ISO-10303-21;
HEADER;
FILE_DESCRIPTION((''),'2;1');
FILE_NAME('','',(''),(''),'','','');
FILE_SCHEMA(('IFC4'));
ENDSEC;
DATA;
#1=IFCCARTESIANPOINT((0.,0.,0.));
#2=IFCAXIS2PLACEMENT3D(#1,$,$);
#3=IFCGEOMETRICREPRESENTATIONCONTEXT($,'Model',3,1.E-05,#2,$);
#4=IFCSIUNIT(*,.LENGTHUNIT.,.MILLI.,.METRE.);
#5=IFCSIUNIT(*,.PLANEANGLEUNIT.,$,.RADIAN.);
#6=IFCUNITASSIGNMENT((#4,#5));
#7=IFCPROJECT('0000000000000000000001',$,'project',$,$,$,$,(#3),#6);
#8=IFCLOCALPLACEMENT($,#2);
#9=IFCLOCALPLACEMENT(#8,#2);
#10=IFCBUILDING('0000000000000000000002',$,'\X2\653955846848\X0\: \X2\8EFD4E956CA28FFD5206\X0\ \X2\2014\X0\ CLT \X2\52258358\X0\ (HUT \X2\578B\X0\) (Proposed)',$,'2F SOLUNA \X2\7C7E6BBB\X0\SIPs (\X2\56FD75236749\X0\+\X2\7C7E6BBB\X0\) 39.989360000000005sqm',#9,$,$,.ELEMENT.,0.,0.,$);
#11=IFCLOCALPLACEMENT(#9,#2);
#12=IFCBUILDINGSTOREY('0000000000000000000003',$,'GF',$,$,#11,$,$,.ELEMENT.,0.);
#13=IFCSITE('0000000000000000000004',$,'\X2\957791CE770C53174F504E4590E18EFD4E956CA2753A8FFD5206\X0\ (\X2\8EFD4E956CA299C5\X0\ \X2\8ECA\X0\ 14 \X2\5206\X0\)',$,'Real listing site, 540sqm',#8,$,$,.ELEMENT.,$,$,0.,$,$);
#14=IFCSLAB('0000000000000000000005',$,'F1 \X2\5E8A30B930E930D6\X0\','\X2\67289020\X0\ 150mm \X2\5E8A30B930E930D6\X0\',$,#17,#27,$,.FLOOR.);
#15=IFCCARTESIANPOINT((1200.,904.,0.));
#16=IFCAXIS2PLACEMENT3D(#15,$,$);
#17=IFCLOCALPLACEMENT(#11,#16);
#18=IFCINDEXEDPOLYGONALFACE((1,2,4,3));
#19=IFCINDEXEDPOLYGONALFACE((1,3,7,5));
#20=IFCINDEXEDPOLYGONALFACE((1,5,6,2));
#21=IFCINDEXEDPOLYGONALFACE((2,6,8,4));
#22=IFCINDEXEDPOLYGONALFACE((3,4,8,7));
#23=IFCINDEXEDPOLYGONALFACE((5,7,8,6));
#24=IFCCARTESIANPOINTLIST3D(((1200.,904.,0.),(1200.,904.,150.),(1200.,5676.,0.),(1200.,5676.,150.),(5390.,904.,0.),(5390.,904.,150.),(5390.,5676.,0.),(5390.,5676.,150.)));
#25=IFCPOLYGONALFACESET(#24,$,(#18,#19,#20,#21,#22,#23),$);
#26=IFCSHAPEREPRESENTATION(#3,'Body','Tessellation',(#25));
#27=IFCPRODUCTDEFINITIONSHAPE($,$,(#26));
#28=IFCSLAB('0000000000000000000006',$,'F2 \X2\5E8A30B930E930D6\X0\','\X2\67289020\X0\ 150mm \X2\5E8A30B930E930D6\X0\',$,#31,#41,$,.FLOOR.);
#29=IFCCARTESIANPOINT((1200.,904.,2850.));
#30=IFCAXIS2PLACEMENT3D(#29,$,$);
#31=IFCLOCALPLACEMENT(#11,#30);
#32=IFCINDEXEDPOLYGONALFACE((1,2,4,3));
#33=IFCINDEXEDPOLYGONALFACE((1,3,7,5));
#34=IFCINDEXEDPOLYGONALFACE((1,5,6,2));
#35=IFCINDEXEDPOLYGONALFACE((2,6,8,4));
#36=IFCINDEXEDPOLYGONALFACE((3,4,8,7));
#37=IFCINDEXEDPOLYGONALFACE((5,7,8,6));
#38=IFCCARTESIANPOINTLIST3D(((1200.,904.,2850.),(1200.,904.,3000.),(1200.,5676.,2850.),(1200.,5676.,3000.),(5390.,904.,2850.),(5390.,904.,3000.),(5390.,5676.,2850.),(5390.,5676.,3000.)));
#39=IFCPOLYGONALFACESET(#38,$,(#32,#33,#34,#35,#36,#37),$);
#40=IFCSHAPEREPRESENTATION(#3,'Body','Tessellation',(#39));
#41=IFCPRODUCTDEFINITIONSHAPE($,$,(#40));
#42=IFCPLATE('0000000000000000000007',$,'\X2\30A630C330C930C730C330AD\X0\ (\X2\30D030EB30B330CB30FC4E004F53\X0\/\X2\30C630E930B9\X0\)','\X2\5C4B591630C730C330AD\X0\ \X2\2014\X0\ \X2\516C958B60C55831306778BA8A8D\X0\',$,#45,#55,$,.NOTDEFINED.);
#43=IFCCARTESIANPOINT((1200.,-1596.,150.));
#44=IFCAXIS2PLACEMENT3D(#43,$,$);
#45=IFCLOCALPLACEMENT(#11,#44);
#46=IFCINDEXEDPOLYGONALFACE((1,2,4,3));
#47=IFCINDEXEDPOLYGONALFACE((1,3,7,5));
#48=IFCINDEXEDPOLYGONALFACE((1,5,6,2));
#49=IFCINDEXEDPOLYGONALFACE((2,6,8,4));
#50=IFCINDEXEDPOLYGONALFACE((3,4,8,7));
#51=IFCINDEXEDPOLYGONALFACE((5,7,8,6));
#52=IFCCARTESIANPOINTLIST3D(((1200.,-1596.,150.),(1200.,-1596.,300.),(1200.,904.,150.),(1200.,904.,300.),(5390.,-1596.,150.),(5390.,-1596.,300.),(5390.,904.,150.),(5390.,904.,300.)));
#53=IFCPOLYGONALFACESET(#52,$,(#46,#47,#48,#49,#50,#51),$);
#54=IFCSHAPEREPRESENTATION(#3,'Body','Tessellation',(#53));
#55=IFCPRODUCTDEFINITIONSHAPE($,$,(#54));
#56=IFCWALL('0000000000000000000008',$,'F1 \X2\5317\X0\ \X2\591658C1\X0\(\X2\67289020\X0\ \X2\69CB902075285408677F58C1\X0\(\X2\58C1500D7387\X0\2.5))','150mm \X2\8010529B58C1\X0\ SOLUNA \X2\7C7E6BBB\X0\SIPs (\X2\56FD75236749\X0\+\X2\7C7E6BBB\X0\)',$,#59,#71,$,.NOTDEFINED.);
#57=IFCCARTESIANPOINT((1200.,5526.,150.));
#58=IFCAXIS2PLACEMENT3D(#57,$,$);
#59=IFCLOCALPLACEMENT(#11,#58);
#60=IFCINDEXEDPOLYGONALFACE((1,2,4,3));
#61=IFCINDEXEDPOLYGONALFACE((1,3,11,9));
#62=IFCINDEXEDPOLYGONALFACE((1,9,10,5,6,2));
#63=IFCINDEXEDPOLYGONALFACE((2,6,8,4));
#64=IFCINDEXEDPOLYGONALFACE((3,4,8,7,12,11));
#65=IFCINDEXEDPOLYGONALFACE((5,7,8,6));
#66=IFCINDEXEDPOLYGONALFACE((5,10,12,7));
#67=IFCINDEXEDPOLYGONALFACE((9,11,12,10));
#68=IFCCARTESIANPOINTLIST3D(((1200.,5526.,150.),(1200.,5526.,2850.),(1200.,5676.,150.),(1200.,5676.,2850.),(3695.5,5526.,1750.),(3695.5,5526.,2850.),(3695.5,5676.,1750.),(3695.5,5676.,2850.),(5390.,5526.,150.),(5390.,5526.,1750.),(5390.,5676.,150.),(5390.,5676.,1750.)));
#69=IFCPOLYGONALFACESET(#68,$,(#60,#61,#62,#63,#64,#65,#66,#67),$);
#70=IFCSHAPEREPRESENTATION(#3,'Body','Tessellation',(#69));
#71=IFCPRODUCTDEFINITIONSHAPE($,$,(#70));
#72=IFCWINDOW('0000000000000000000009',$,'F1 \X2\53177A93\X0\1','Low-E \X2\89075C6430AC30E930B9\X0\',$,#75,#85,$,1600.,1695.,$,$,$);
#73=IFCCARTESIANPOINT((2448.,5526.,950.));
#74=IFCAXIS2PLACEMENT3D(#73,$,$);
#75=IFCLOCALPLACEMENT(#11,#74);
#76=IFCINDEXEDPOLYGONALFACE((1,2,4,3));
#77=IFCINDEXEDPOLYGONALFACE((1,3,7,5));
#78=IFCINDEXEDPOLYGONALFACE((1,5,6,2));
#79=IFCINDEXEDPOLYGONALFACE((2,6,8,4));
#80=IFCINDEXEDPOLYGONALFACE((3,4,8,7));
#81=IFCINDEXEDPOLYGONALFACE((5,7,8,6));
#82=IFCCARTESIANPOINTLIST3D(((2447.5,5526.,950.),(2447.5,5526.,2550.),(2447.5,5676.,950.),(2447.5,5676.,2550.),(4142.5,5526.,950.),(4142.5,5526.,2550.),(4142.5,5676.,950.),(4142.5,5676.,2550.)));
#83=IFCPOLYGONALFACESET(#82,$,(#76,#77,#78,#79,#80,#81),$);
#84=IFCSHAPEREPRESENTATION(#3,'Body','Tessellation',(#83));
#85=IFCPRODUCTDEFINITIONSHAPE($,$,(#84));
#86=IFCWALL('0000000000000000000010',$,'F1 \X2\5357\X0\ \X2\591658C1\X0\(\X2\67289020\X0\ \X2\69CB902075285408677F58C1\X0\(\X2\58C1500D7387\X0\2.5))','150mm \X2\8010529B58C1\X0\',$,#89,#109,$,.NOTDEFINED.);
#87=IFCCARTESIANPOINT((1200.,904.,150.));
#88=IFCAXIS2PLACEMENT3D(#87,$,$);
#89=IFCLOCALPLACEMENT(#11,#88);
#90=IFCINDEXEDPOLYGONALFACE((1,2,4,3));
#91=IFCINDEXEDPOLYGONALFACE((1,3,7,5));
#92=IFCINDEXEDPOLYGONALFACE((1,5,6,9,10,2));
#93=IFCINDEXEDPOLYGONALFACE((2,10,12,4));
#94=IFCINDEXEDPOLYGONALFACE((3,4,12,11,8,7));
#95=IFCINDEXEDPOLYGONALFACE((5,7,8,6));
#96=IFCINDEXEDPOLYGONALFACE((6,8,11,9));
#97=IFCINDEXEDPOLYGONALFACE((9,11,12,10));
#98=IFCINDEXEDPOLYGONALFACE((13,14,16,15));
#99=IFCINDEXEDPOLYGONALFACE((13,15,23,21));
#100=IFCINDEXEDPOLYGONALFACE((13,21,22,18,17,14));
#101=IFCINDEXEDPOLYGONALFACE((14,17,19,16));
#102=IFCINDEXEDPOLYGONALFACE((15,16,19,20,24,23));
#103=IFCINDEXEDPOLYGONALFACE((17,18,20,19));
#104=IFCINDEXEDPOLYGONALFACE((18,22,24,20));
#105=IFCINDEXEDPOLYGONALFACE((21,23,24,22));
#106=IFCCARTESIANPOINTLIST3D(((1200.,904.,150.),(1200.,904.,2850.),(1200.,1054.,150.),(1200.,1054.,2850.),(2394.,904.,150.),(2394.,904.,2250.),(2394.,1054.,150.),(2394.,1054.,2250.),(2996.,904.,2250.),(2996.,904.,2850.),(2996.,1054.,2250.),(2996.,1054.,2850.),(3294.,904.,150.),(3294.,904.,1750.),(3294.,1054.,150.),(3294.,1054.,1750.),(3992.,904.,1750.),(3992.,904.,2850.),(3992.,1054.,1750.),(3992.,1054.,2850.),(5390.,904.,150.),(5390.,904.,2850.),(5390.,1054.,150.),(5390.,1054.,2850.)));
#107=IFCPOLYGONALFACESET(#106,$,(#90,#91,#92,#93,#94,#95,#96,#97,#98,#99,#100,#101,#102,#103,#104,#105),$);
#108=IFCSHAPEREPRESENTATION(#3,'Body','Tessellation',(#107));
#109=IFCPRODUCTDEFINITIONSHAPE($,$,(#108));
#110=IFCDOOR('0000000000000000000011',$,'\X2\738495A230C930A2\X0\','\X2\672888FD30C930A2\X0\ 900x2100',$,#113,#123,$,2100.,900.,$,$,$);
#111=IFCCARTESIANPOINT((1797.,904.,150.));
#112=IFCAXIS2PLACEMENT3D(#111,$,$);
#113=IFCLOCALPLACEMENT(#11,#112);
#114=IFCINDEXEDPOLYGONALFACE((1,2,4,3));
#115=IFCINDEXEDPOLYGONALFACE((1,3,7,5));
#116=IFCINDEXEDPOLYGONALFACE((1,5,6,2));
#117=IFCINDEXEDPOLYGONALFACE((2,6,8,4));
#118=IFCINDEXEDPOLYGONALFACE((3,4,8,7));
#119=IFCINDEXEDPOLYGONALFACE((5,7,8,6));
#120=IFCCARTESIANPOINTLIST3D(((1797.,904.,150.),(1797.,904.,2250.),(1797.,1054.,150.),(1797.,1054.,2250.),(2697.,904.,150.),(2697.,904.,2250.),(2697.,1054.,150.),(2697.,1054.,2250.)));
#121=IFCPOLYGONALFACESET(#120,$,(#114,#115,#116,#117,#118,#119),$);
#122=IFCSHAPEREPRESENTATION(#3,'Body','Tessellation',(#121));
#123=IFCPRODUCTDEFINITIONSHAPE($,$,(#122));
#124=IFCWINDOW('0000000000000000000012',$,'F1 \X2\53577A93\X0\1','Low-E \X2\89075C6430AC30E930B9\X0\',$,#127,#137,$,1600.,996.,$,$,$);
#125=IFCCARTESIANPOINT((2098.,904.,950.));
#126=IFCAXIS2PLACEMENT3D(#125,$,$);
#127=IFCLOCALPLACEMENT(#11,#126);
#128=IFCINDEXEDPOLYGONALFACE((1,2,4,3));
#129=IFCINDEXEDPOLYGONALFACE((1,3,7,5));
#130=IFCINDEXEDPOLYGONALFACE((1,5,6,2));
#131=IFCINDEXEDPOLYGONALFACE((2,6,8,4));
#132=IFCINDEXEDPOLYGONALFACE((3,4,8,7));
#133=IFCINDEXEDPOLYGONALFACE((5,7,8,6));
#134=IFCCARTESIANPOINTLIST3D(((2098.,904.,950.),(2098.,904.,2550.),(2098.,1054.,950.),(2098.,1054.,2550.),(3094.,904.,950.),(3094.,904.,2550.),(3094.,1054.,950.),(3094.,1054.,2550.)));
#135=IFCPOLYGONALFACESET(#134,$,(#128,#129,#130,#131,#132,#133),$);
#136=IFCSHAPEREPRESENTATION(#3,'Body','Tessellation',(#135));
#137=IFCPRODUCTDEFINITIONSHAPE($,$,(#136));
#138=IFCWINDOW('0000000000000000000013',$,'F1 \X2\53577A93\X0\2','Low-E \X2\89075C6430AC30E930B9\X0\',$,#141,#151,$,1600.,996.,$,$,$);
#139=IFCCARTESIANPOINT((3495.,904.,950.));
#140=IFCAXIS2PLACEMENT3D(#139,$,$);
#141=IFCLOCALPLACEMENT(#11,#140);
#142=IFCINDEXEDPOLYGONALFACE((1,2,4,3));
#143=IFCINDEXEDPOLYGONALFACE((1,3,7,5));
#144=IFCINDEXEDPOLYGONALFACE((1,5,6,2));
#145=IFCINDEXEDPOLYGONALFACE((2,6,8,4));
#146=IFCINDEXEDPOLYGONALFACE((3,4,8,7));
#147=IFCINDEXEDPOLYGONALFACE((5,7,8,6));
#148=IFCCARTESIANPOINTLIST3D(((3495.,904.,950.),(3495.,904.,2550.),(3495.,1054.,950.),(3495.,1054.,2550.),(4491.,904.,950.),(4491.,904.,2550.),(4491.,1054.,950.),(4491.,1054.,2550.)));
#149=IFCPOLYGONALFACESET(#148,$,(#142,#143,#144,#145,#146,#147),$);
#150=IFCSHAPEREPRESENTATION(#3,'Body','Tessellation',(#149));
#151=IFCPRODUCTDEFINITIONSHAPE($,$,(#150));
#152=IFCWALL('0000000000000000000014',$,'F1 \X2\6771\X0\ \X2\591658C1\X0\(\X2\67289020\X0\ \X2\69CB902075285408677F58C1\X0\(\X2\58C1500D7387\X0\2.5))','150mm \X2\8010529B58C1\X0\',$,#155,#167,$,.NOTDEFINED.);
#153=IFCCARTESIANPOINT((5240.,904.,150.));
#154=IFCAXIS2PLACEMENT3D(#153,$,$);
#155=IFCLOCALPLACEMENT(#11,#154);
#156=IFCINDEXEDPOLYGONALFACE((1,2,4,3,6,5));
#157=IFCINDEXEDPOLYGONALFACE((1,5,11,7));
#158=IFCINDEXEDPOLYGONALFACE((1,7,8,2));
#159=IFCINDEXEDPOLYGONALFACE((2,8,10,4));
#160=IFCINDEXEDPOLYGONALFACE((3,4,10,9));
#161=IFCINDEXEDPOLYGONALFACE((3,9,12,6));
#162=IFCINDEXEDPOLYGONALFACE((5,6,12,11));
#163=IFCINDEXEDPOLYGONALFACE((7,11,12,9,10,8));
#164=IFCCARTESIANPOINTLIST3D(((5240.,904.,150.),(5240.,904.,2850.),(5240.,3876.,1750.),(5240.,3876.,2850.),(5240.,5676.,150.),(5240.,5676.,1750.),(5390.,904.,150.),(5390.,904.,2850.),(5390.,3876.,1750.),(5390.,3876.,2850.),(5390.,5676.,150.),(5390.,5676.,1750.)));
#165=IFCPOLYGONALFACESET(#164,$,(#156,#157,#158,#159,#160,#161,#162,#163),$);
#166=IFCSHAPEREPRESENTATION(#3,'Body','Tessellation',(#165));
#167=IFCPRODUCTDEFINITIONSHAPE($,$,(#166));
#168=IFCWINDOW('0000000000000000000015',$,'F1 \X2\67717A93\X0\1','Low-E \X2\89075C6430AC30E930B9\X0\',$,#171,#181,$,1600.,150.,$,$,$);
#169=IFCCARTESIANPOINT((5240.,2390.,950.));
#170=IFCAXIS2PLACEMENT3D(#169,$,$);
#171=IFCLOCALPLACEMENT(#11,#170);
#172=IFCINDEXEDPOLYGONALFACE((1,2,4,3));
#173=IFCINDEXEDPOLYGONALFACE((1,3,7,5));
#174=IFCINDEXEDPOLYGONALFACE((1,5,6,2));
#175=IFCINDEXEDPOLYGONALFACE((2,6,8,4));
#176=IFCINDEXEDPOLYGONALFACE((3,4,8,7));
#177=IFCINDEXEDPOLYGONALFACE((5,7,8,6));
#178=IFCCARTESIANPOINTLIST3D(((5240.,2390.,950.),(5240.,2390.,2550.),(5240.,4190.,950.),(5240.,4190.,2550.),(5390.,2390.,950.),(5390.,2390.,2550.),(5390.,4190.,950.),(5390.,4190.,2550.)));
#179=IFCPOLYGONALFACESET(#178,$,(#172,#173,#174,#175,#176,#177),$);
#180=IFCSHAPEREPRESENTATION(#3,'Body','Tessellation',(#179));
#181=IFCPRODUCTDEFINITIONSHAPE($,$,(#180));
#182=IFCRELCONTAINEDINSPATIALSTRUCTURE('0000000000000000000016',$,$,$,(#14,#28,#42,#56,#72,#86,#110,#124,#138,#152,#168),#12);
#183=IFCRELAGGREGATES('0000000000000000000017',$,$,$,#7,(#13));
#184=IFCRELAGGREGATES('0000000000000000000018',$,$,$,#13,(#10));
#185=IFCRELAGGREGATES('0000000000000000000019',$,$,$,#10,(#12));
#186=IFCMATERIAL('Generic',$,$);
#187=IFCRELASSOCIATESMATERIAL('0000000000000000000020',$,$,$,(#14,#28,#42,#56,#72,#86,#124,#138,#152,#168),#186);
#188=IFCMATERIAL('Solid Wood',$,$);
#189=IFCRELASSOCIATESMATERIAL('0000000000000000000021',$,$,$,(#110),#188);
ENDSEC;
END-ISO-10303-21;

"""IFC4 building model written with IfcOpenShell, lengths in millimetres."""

from ifc_helpers import new_model, si_unit, frame, frame_2d, origin, place, context, project, spatial, rectangle, extrude, material, element, fill, save


model = new_model("IFC4")

# Units and contexts
model_context = context("Model", 3, precision=1e-05, world=origin())
ifc_project = project(units=[si_unit("LENGTHUNIT", "METRE", prefix="MILLI"), si_unit("PLANEANGLEUNIT", "RADIAN")], contexts=[model_context])

# Site, building, storey
site_placement = place(None, origin())
site = spatial("IfcSite", under=ifc_project, at=site_placement, Name="長野県北佐久郡軽井沢町追分 (軽井沢駅 車 14 分)", ObjectType="Real listing site, 540sqm", CompositionType="ELEMENT", RefElevation=0.0)
building_placement = place(site_placement, origin())
building = spatial("IfcBuilding", under=site, at=building_placement, Name="改善案: 軽井沢追分 — CLT 別荘 (HUT 型) (Proposed)", ObjectType="2F SOLUNA 籾殻SIPs (国産杉+籾殻) 39.989360000000005sqm", CompositionType="ELEMENT", ElevationOfRefHeight=0.0, ElevationOfTerrain=0.0)
storey_placement = place(building_placement, origin())
storey = spatial("IfcBuildingStorey", under=building, at=storey_placement, Name="GF", CompositionType="ELEMENT", Elevation=0.0)

# Slabs
ifc_material_1 = material(Name="Generic")
slab_1_placement = place(storey_placement, frame((1200.0, 904.0, 0.0)))
element("IfcSlab", 1, at=slab_1_placement, inside=storey, material=ifc_material_1, Name="F1 床スラブ", Description="木造 150mm 床スラブ", PredefinedType="FLOOR", context=model_context, shape_type="SweptSolid", body=[
    extrude(rectangle(XDim=4190.0, YDim=4772.0, at=frame_2d((2095.0, 2386.0))), frame((1200.0, 904.0, 0.0)), (0.0, 0.0, 1.0), 150.0),
])
slab_2_placement = place(storey_placement, frame((1200.0, 904.0, 2850.0)))
element("IfcSlab", 2, at=slab_2_placement, inside=storey, material=ifc_material_1, Name="F2 床スラブ", Description="木造 150mm 床スラブ", PredefinedType="FLOOR", context=model_context, shape_type="SweptSolid", body=[
    extrude(rectangle(XDim=4190.0, YDim=4772.0, at=frame_2d((2095.0, 2386.0))), frame((1200.0, 904.0, 2850.0)), (0.0, 0.0, 1.0), 150.0),
])

# Plate
plate_placement = place(storey_placement, frame((1200.0, -1596.0, 150.0)))
element("IfcPlate", 3, at=plate_placement, inside=storey, material=ifc_material_1, Name="ウッドデッキ (バルコニー一体/テラス)", Description="屋外デッキ — 公開情報で確認", PredefinedType="NOTDEFINED", context=model_context, shape_type="SweptSolid", body=[
    extrude(rectangle(XDim=4190.0, YDim=2500.0, at=frame_2d((2095.0, 1250.0))), frame((1200.0, -1596.0, 150.0)), (0.0, 0.0, 1.0), 150.0),
])

# Wall, opening, window
wall_1_placement = place(storey_placement, frame((1200.0, 5526.0, 150.0)))
wall_1 = element("IfcWall", 4, at=wall_1_placement, inside=storey, material=ifc_material_1, Name="F1 北 外壁(木造 構造用合板壁(壁倍率2.5))", Description="150mm 耐力壁 SOLUNA 籾殻SIPs (国産杉+籾殻)", PredefinedType="NOTDEFINED", context=model_context, shape_type="SweptSolid", body=[
    extrude(rectangle(XDim=4190.0, YDim=150.0, at=frame_2d((2095.0, 75.0))), frame((1200.0, 5526.0, 150.0)), (0.0, 0.0, 1.0), 2700.0),
])
opening_1_placement = place(storey_placement, frame((2448.0, 5526.0, 950.0)))
opening_1 = element("IfcOpeningElement", 5, at=opening_1_placement, cuts=wall_1, PredefinedType="NOTDEFINED", context=model_context, shape_type="SweptSolid", body=[
    extrude(rectangle(XDim=1695.0, YDim=150.0, at=frame_2d((847.0, 75.0))), frame((2448.0, 5526.0, 950.0)), (0.0, 0.0, 1.0), 1600.0),
])
window_1_placement = place(storey_placement, frame((2448.0, 5526.0, 950.0)))
window_1 = element("IfcWindow", 6, at=window_1_placement, inside=storey, material=ifc_material_1, Name="F1 北窓1", Description="Low-E 複層ガラス", OverallHeight=1600.0, OverallWidth=1695.0, context=model_context, shape_type="SweptSolid", body=[
    extrude(rectangle(XDim=1695.0, YDim=150.0, at=frame_2d((847.0, 75.0))), frame((2448.0, 5526.0, 950.0)), (0.0, 0.0, 1.0), 1600.0),
])
fill(opening_1, window_1)

# Wall, openings, door, windows
wall_2_placement = place(storey_placement, frame((1200.0, 904.0, 150.0)))
wall_2 = element("IfcWall", 7, at=wall_2_placement, inside=storey, material=ifc_material_1, Name="F1 南 外壁(木造 構造用合板壁(壁倍率2.5))", Description="150mm 耐力壁", PredefinedType="NOTDEFINED", context=model_context, shape_type="SweptSolid", body=[
    extrude(rectangle(XDim=4190.0, YDim=150.0, at=frame_2d((2095.0, 75.0))), frame((1200.0, 904.0, 150.0)), (0.0, 0.0, 1.0), 2700.0),
])
opening_2_placement = place(storey_placement, frame((1797.0, 904.0, 150.0)))
opening_2 = element("IfcOpeningElement", 8, at=opening_2_placement, cuts=wall_2, PredefinedType="NOTDEFINED", context=model_context, shape_type="SweptSolid", body=[
    extrude(rectangle(XDim=900.0, YDim=150.0, at=frame_2d((450.0, 75.0))), frame((1797.0, 904.0, 150.0)), (0.0, 0.0, 1.0), 2100.0),
])
opening_3_placement = place(storey_placement, frame((2098.0, 904.0, 950.0)))
opening_3 = element("IfcOpeningElement", 9, at=opening_3_placement, cuts=wall_2, PredefinedType="NOTDEFINED", context=model_context, shape_type="SweptSolid", body=[
    extrude(rectangle(XDim=996.0, YDim=150.0, at=frame_2d((498.0, 75.0))), frame((2098.0, 904.0, 950.0)), (0.0, 0.0, 1.0), 1600.0),
])
opening_4_placement = place(storey_placement, frame((3495.0, 904.0, 950.0)))
opening_4 = element("IfcOpeningElement", 10, at=opening_4_placement, cuts=wall_2, PredefinedType="NOTDEFINED", context=model_context, shape_type="SweptSolid", body=[
    extrude(rectangle(XDim=996.0, YDim=150.0, at=frame_2d((498.0, 75.0))), frame((3495.0, 904.0, 950.0)), (0.0, 0.0, 1.0), 1600.0),
])
ifc_material_2 = material(Name="Solid Wood")
door_placement = place(storey_placement, frame((1797.0, 904.0, 150.0)))
door = element("IfcDoor", 11, at=door_placement, inside=storey, material=ifc_material_2, Name="玄関ドア", Description="木製ドア 900x2100", OverallHeight=2100.0, OverallWidth=900.0, context=model_context, shape_type="SweptSolid", body=[
    extrude(rectangle(XDim=900.0, YDim=150.0, at=frame_2d((450.0, 75.0))), frame((1797.0, 904.0, 150.0)), (0.0, 0.0, 1.0), 2100.0),
])
fill(opening_2, door)
window_2_placement = place(storey_placement, frame((2098.0, 904.0, 950.0)))
window_2 = element("IfcWindow", 12, at=window_2_placement, inside=storey, material=ifc_material_1, Name="F1 南窓1", Description="Low-E 複層ガラス", OverallHeight=1600.0, OverallWidth=996.0, context=model_context, shape_type="SweptSolid", body=[
    extrude(rectangle(XDim=996.0, YDim=150.0, at=frame_2d((498.0, 75.0))), frame((2098.0, 904.0, 950.0)), (0.0, 0.0, 1.0), 1600.0),
])
fill(opening_3, window_2)
window_3_placement = place(storey_placement, frame((3495.0, 904.0, 950.0)))
window_3 = element("IfcWindow", 13, at=window_3_placement, inside=storey, material=ifc_material_1, Name="F1 南窓2", Description="Low-E 複層ガラス", OverallHeight=1600.0, OverallWidth=996.0, context=model_context, shape_type="SweptSolid", body=[
    extrude(rectangle(XDim=996.0, YDim=150.0, at=frame_2d((498.0, 75.0))), frame((3495.0, 904.0, 950.0)), (0.0, 0.0, 1.0), 1600.0),
])
fill(opening_4, window_3)

# Wall, opening, window
wall_3_placement = place(storey_placement, frame((5240.0, 904.0, 150.0)))
wall_3 = element("IfcWall", 14, at=wall_3_placement, inside=storey, material=ifc_material_1, Name="F1 東 外壁(木造 構造用合板壁(壁倍率2.5))", Description="150mm 耐力壁", PredefinedType="NOTDEFINED", context=model_context, shape_type="SweptSolid", body=[
    extrude(rectangle(XDim=150.0, YDim=4772.0, at=frame_2d((75.0, 2386.0))), frame((5240.0, 904.0, 150.0)), (0.0, 0.0, 1.0), 2700.0),
])
opening_5_placement = place(storey_placement, frame((5240.0, 2390.0, 950.0)))
opening_5 = element("IfcOpeningElement", 15, at=opening_5_placement, cuts=wall_3, PredefinedType="NOTDEFINED", context=model_context, shape_type="SweptSolid", body=[
    extrude(rectangle(XDim=150.0, YDim=1800.0, at=frame_2d((75.0, 900.0))), frame((5240.0, 2390.0, 950.0)), (0.0, 0.0, 1.0), 1600.0),
])
window_4_placement = place(storey_placement, frame((5240.0, 2390.0, 950.0)))
window_4 = element("IfcWindow", 16, at=window_4_placement, inside=storey, material=ifc_material_1, Name="F1 東窓1", Description="Low-E 複層ガラス", OverallHeight=1600.0, OverallWidth=150.0, context=model_context, shape_type="SweptSolid", body=[
    extrude(rectangle(XDim=150.0, YDim=1800.0, at=frame_2d((75.0, 900.0))), frame((5240.0, 2390.0, 950.0)), (0.0, 0.0, 1.0), 1600.0),
])
fill(opening_5, window_4)

save(model, "model.ifc")
